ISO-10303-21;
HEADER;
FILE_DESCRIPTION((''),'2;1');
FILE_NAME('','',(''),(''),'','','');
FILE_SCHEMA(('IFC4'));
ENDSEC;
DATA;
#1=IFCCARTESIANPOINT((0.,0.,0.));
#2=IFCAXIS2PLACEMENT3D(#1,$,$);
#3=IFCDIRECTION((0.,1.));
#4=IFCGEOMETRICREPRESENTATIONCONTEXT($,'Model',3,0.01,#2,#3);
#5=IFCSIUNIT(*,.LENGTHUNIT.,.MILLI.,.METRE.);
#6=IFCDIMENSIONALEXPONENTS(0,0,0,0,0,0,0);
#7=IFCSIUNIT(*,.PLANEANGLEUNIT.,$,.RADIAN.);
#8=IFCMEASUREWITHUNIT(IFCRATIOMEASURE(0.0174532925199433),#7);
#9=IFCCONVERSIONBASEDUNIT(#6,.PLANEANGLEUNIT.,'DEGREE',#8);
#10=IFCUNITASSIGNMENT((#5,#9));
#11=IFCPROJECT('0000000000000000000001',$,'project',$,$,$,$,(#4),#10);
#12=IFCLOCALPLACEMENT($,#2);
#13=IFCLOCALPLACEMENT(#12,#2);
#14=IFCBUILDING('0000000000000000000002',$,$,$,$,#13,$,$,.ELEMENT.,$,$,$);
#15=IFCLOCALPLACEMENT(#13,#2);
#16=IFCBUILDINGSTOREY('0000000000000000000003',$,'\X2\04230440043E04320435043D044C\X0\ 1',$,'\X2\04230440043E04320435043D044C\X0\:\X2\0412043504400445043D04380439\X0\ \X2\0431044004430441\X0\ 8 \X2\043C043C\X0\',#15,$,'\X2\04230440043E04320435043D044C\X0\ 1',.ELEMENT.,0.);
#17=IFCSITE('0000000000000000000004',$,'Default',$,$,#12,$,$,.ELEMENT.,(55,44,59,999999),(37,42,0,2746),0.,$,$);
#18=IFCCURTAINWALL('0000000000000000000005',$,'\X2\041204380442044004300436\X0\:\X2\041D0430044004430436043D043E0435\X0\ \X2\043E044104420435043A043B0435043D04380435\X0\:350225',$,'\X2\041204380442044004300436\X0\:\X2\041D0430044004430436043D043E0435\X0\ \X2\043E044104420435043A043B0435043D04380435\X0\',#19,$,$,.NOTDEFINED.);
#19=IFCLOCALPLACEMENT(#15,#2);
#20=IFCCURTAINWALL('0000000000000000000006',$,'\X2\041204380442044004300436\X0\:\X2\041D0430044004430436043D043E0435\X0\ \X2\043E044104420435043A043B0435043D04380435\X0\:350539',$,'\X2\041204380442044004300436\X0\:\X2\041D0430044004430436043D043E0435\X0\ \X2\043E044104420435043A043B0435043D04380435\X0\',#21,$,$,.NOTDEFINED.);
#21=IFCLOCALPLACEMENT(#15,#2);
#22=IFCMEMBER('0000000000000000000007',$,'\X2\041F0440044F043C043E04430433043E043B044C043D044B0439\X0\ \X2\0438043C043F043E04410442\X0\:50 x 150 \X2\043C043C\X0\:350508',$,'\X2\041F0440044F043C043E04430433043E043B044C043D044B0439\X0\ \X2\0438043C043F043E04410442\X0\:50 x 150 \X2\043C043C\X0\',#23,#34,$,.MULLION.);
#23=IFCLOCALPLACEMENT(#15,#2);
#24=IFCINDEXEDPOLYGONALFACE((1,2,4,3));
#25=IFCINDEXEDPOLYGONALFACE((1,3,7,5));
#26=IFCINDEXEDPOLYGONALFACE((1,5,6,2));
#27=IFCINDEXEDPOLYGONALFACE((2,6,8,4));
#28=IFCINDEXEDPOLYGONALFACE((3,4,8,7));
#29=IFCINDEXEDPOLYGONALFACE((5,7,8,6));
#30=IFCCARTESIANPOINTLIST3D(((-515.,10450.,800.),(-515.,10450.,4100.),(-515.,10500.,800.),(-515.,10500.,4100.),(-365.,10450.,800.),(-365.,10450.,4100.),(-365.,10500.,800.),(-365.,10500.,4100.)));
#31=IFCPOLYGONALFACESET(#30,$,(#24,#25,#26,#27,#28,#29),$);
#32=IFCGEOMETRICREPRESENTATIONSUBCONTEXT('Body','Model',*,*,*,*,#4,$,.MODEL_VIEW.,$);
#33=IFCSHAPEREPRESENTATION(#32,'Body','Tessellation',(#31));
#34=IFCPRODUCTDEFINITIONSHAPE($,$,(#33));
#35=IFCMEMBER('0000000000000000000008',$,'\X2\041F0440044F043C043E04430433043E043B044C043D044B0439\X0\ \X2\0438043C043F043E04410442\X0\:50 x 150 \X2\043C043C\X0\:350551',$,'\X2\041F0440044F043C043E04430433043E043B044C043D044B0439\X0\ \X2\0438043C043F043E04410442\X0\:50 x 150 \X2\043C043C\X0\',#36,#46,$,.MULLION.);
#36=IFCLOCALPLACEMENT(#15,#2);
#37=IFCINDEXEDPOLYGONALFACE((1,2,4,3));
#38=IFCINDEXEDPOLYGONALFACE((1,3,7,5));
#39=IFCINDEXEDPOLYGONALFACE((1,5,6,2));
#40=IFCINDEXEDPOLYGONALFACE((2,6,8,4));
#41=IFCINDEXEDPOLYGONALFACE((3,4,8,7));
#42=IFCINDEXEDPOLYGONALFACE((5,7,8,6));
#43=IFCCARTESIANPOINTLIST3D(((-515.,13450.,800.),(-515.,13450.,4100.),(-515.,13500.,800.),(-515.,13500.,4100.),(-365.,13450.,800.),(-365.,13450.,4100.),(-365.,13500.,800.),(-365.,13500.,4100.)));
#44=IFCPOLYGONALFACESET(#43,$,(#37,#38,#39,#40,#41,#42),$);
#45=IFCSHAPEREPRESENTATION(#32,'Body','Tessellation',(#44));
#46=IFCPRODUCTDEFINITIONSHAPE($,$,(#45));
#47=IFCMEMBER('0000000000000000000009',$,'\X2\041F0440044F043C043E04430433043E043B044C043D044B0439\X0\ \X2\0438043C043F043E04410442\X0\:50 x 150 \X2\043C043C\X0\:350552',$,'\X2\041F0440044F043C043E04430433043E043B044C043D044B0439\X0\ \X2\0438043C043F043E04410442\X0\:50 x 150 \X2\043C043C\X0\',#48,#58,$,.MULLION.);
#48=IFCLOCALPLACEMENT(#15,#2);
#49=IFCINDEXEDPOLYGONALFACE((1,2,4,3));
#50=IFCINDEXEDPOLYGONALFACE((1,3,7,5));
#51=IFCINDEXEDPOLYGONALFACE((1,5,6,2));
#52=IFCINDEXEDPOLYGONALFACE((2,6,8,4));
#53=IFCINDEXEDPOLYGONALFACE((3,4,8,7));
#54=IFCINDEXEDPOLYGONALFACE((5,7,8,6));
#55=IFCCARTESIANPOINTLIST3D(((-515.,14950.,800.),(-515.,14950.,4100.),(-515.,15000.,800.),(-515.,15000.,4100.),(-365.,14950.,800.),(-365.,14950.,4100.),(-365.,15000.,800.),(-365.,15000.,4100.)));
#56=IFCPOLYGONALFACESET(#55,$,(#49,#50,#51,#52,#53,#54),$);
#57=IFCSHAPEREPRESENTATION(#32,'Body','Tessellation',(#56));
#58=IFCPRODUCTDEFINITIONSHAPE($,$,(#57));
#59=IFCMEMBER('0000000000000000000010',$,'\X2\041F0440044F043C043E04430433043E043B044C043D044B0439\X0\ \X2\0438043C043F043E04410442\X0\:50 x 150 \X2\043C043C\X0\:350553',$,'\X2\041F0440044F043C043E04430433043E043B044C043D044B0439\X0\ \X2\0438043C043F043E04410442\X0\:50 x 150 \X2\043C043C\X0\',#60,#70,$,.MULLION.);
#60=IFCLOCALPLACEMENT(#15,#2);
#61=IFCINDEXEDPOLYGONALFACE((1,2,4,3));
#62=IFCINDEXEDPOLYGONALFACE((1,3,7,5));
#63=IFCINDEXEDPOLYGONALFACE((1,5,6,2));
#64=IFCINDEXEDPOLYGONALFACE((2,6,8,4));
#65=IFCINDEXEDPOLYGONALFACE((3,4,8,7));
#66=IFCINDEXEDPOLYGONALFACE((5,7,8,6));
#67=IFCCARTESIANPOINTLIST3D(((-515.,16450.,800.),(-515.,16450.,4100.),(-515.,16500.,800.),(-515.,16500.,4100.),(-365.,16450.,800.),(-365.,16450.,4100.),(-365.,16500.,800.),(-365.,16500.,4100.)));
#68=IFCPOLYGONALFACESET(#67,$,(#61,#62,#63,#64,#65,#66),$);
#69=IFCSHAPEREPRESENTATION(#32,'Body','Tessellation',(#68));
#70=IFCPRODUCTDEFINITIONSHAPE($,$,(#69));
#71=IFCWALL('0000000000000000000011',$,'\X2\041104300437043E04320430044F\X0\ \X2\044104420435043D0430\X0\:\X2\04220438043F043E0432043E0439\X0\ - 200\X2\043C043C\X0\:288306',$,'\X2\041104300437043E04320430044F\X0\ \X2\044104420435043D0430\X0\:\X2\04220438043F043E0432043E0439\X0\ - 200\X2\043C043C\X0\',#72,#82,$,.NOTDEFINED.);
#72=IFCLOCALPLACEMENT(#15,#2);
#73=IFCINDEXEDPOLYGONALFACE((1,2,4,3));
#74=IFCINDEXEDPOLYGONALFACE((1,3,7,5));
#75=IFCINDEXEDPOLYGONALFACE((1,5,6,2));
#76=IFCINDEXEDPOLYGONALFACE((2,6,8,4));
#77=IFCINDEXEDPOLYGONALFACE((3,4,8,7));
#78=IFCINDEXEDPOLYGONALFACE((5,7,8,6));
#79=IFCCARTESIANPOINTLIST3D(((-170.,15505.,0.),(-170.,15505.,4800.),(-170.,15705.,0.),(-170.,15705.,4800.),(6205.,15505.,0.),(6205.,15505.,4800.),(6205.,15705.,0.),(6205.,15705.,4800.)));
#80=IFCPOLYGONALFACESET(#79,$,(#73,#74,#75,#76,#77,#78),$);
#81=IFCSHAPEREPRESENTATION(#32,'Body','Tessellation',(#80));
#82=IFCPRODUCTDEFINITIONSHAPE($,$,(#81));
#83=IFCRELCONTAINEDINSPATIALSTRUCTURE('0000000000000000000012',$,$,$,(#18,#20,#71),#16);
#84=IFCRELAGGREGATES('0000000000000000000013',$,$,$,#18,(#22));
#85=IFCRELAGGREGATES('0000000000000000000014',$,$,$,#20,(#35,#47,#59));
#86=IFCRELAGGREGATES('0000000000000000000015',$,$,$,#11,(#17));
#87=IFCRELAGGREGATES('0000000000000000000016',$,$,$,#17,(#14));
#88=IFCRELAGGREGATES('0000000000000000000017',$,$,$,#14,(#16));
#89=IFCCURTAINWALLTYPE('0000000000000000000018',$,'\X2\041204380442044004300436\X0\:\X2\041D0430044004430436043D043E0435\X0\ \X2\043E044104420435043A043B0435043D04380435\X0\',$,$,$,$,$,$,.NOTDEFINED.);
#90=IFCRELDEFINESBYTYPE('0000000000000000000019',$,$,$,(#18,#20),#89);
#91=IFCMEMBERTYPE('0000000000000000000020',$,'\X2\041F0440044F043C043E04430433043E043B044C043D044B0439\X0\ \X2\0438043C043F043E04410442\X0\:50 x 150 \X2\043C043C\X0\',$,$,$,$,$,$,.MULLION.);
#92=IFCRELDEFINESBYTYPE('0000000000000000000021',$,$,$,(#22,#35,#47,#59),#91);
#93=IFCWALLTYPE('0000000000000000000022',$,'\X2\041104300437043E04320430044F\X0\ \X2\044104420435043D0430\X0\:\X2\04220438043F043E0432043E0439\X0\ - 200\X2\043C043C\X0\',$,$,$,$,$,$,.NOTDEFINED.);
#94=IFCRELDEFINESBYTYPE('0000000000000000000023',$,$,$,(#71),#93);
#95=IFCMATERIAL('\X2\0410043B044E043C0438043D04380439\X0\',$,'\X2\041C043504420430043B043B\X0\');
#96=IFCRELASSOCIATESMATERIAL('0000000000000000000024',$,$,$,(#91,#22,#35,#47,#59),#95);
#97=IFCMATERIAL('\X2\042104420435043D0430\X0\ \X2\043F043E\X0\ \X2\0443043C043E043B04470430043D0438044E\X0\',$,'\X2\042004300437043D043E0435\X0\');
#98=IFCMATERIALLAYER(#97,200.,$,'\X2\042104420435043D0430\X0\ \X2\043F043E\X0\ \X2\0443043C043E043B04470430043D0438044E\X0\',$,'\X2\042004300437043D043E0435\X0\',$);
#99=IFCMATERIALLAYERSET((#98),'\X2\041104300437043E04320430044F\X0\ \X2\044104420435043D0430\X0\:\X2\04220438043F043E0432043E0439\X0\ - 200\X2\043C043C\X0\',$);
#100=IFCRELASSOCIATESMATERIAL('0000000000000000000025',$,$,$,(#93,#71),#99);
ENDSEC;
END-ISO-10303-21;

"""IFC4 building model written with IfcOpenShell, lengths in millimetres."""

from ifc_helpers import new_model, entity, si_unit, converted_unit, direction, frame, frame_2d, origin, origin_2d_with_axis, place, context, subcontext, project, spatial, rectangle, extrude, source, transform, mapped, material, layer, layer_set, layer_usage, material_profile, profile_set, profile_usage, type_object, type_shapes, element, aggregate, save


model = new_model("IFC4")

# Units and contexts
model_context = context("Model", 3, precision=0.01, world=origin(), true_north=direction((0.0, 1.0)))
body_context = subcontext(model_context, "Body", "Model", "MODEL_VIEW")
ifc_project = project(units=[si_unit("LENGTHUNIT", "METRE", prefix="MILLI"), converted_unit("PLANEANGLEUNIT", "DEGREE", entity("IfcRatioMeasure", 0.0174532925199433), si_unit("PLANEANGLEUNIT", "RADIAN"), dimensions=[0, 0, 0, 0, 0, 0, 0])], contexts=[model_context])

# Site, building, storey
site_placement = place(None, origin())
site = spatial("IfcSite", under=ifc_project, at=site_placement, Name="Default", CompositionType="ELEMENT", RefLatitude=(55, 44, 59, 999999), RefLongitude=(37, 42, 0, 2746), RefElevation=0.0)
building_placement = place(site_placement, origin())
building = spatial("IfcBuilding", under=site, at=building_placement, CompositionType="ELEMENT")
storey_placement = place(building_placement, origin())
storey = spatial("IfcBuildingStorey", under=building, at=storey_placement, Name="Уровень 1", ObjectType="Уровень:Верхний брус 8 мм", LongName="Уровень 1", CompositionType="ELEMENT", Elevation=0.0)

# Curtain walls
curtain_wall_type = type_object("IfcCurtainWallType", Name="Витраж:Наружное остекление", PredefinedType="NOTDEFINED")
curtain_wall_1_placement = place(storey_placement, origin())
curtain_wall_1 = element("IfcCurtainWall", 1, at=curtain_wall_1_placement, inside=storey, type_object=curtain_wall_type, Name="Витраж:Наружное остекление:350225", ObjectType="Витраж:Наружное остекление", PredefinedType="NOTDEFINED")
ifc_material_1 = material(Name="Алюминий", Category="Металл")
ifc_material_profile = material_profile(ifc_material_1, rectangle(XDim=150.0, YDim=50.0, at=origin_2d_with_axis()), Name="50 x 150 мм")
ifc_profile_set = profile_set([ifc_material_profile], Name="50 x 150 мм")
curtain_wall_2_placement = place(storey_placement, origin())
curtain_wall_2 = element("IfcCurtainWall", 2, at=curtain_wall_2_placement, inside=storey, type_object=curtain_wall_type, Name="Витраж:Наружное остекление:350539", ObjectType="Витраж:Наружное остекление", PredefinedType="NOTDEFINED")

# Members
ifc_profile_usage_1 = profile_usage(ifc_profile_set)
member_type_1 = type_object("IfcMemberType", Name="Прямоугольный импост:50 x 150 мм", PredefinedType="MULLION", material=ifc_profile_set)
shared_shape_1 = source(origin(), body_context, "Body", "SweptSolid", [
    extrude(rectangle(XDim=150.0, YDim=50.0, at=origin_2d_with_axis()), frame((0.0, 0.0, -3300.0), z_axis=(0.0, 0.0, 1.0), x_axis=(0.0, -1.0, 0.0)), (0.0, 0.0, 1.0), 3300.0),
])
type_shapes(member_type_1, [shared_shape_1])
member_1_placement = place(storey_placement, frame((-440.0, 10475.0, 800.0), z_axis=(0.0, 0.0, -1.0), x_axis=(0.0, 1.0, 0.0)))
member_1 = element("IfcMember", 3, at=member_1_placement, type_object=member_type_1, material=ifc_profile_usage_1, Name="Прямоугольный импост:50 x 150 мм:350508", ObjectType="Прямоугольный импост:50 x 150 мм", PredefinedType="MULLION", context=body_context, shape_type="MappedRepresentation", body=[
    mapped(shared_shape_1, transform((0.0, 0.0, 0.0), scale=1.0)),
])
ifc_profile_usage_2 = profile_usage(ifc_profile_set)
member_2_placement = place(storey_placement, frame((-440.0, 13475.0, 800.0), z_axis=(0.0, 0.0, -1.0), x_axis=(0.0, 1.0, 0.0)))
member_2 = element("IfcMember", 4, at=member_2_placement, type_object=member_type_1, material=ifc_profile_usage_2, Name="Прямоугольный импост:50 x 150 мм:350551", ObjectType="Прямоугольный импост:50 x 150 мм", PredefinedType="MULLION", context=body_context, shape_type="MappedRepresentation", body=[
    mapped(shared_shape_1, transform((0.0, 0.0, 0.0), scale=1.0)),
])
ifc_profile_usage_3 = profile_usage(ifc_profile_set)
member_3_placement = place(storey_placement, frame((-440.0, 14975.0, 800.0), z_axis=(0.0, 0.0, -1.0), x_axis=(0.0, 1.0, 0.0)))
member_3 = element("IfcMember", 5, at=member_3_placement, type_object=member_type_1, material=ifc_profile_usage_3, Name="Прямоугольный импост:50 x 150 мм:350552", ObjectType="Прямоугольный импост:50 x 150 мм", PredefinedType="MULLION", context=body_context, shape_type="MappedRepresentation", body=[
    mapped(shared_shape_1, transform((0.0, 0.0, 0.0), scale=1.0)),
])
ifc_profile_usage_4 = profile_usage(ifc_profile_set)
member_4_placement = place(storey_placement, frame((-440.0, 16475.0, 800.0), z_axis=(0.0, 0.0, -1.0), x_axis=(0.0, 1.0, 0.0)))
member_4 = element("IfcMember", 6, at=member_4_placement, type_object=member_type_1, material=ifc_profile_usage_4, Name="Прямоугольный импост:50 x 150 мм:350553", ObjectType="Прямоугольный импост:50 x 150 мм", PredefinedType="MULLION", context=body_context, shape_type="MappedRepresentation", body=[
    mapped(shared_shape_1, transform((0.0, 0.0, 0.0), scale=1.0)),
])

aggregate(curtain_wall_1, [member_1])
aggregate(curtain_wall_2, [member_2, member_3, member_4])

# Wall
ifc_material_2 = material(Name="Стена по умолчанию", Category="Разное")
ifc_layer = layer(ifc_material_2, 200.0, Name="Стена по умолчанию", Category="Разное")
ifc_layer_set = layer_set([ifc_layer], Name="Базовая стена:Типовой - 200мм")
ifc_layer_usage = layer_usage(ifc_layer_set, "AXIS2", "NEGATIVE", 100.0)
wall_type = type_object("IfcWallType", Name="Базовая стена:Типовой - 200мм", PredefinedType="NOTDEFINED", material=ifc_layer_set)
wall_placement = place(storey_placement, frame((-170.0, 15605.0, 0.0)))
element("IfcWall", 7, at=wall_placement, inside=storey, type_object=wall_type, material=ifc_layer_usage, Name="Базовая стена:Типовой - 200мм:288306", ObjectType="Базовая стена:Типовой - 200мм", PredefinedType="NOTDEFINED", context=body_context, shape_type="SweptSolid", body=[
    extrude(rectangle(XDim=6375.0, YDim=200.0, at=frame_2d((3187.5, 0.0), x_axis=(-1.0, 0.0))), origin(), (0.0, 0.0, 1.0), 4800.0),
])

save(model, "model.ifc")
